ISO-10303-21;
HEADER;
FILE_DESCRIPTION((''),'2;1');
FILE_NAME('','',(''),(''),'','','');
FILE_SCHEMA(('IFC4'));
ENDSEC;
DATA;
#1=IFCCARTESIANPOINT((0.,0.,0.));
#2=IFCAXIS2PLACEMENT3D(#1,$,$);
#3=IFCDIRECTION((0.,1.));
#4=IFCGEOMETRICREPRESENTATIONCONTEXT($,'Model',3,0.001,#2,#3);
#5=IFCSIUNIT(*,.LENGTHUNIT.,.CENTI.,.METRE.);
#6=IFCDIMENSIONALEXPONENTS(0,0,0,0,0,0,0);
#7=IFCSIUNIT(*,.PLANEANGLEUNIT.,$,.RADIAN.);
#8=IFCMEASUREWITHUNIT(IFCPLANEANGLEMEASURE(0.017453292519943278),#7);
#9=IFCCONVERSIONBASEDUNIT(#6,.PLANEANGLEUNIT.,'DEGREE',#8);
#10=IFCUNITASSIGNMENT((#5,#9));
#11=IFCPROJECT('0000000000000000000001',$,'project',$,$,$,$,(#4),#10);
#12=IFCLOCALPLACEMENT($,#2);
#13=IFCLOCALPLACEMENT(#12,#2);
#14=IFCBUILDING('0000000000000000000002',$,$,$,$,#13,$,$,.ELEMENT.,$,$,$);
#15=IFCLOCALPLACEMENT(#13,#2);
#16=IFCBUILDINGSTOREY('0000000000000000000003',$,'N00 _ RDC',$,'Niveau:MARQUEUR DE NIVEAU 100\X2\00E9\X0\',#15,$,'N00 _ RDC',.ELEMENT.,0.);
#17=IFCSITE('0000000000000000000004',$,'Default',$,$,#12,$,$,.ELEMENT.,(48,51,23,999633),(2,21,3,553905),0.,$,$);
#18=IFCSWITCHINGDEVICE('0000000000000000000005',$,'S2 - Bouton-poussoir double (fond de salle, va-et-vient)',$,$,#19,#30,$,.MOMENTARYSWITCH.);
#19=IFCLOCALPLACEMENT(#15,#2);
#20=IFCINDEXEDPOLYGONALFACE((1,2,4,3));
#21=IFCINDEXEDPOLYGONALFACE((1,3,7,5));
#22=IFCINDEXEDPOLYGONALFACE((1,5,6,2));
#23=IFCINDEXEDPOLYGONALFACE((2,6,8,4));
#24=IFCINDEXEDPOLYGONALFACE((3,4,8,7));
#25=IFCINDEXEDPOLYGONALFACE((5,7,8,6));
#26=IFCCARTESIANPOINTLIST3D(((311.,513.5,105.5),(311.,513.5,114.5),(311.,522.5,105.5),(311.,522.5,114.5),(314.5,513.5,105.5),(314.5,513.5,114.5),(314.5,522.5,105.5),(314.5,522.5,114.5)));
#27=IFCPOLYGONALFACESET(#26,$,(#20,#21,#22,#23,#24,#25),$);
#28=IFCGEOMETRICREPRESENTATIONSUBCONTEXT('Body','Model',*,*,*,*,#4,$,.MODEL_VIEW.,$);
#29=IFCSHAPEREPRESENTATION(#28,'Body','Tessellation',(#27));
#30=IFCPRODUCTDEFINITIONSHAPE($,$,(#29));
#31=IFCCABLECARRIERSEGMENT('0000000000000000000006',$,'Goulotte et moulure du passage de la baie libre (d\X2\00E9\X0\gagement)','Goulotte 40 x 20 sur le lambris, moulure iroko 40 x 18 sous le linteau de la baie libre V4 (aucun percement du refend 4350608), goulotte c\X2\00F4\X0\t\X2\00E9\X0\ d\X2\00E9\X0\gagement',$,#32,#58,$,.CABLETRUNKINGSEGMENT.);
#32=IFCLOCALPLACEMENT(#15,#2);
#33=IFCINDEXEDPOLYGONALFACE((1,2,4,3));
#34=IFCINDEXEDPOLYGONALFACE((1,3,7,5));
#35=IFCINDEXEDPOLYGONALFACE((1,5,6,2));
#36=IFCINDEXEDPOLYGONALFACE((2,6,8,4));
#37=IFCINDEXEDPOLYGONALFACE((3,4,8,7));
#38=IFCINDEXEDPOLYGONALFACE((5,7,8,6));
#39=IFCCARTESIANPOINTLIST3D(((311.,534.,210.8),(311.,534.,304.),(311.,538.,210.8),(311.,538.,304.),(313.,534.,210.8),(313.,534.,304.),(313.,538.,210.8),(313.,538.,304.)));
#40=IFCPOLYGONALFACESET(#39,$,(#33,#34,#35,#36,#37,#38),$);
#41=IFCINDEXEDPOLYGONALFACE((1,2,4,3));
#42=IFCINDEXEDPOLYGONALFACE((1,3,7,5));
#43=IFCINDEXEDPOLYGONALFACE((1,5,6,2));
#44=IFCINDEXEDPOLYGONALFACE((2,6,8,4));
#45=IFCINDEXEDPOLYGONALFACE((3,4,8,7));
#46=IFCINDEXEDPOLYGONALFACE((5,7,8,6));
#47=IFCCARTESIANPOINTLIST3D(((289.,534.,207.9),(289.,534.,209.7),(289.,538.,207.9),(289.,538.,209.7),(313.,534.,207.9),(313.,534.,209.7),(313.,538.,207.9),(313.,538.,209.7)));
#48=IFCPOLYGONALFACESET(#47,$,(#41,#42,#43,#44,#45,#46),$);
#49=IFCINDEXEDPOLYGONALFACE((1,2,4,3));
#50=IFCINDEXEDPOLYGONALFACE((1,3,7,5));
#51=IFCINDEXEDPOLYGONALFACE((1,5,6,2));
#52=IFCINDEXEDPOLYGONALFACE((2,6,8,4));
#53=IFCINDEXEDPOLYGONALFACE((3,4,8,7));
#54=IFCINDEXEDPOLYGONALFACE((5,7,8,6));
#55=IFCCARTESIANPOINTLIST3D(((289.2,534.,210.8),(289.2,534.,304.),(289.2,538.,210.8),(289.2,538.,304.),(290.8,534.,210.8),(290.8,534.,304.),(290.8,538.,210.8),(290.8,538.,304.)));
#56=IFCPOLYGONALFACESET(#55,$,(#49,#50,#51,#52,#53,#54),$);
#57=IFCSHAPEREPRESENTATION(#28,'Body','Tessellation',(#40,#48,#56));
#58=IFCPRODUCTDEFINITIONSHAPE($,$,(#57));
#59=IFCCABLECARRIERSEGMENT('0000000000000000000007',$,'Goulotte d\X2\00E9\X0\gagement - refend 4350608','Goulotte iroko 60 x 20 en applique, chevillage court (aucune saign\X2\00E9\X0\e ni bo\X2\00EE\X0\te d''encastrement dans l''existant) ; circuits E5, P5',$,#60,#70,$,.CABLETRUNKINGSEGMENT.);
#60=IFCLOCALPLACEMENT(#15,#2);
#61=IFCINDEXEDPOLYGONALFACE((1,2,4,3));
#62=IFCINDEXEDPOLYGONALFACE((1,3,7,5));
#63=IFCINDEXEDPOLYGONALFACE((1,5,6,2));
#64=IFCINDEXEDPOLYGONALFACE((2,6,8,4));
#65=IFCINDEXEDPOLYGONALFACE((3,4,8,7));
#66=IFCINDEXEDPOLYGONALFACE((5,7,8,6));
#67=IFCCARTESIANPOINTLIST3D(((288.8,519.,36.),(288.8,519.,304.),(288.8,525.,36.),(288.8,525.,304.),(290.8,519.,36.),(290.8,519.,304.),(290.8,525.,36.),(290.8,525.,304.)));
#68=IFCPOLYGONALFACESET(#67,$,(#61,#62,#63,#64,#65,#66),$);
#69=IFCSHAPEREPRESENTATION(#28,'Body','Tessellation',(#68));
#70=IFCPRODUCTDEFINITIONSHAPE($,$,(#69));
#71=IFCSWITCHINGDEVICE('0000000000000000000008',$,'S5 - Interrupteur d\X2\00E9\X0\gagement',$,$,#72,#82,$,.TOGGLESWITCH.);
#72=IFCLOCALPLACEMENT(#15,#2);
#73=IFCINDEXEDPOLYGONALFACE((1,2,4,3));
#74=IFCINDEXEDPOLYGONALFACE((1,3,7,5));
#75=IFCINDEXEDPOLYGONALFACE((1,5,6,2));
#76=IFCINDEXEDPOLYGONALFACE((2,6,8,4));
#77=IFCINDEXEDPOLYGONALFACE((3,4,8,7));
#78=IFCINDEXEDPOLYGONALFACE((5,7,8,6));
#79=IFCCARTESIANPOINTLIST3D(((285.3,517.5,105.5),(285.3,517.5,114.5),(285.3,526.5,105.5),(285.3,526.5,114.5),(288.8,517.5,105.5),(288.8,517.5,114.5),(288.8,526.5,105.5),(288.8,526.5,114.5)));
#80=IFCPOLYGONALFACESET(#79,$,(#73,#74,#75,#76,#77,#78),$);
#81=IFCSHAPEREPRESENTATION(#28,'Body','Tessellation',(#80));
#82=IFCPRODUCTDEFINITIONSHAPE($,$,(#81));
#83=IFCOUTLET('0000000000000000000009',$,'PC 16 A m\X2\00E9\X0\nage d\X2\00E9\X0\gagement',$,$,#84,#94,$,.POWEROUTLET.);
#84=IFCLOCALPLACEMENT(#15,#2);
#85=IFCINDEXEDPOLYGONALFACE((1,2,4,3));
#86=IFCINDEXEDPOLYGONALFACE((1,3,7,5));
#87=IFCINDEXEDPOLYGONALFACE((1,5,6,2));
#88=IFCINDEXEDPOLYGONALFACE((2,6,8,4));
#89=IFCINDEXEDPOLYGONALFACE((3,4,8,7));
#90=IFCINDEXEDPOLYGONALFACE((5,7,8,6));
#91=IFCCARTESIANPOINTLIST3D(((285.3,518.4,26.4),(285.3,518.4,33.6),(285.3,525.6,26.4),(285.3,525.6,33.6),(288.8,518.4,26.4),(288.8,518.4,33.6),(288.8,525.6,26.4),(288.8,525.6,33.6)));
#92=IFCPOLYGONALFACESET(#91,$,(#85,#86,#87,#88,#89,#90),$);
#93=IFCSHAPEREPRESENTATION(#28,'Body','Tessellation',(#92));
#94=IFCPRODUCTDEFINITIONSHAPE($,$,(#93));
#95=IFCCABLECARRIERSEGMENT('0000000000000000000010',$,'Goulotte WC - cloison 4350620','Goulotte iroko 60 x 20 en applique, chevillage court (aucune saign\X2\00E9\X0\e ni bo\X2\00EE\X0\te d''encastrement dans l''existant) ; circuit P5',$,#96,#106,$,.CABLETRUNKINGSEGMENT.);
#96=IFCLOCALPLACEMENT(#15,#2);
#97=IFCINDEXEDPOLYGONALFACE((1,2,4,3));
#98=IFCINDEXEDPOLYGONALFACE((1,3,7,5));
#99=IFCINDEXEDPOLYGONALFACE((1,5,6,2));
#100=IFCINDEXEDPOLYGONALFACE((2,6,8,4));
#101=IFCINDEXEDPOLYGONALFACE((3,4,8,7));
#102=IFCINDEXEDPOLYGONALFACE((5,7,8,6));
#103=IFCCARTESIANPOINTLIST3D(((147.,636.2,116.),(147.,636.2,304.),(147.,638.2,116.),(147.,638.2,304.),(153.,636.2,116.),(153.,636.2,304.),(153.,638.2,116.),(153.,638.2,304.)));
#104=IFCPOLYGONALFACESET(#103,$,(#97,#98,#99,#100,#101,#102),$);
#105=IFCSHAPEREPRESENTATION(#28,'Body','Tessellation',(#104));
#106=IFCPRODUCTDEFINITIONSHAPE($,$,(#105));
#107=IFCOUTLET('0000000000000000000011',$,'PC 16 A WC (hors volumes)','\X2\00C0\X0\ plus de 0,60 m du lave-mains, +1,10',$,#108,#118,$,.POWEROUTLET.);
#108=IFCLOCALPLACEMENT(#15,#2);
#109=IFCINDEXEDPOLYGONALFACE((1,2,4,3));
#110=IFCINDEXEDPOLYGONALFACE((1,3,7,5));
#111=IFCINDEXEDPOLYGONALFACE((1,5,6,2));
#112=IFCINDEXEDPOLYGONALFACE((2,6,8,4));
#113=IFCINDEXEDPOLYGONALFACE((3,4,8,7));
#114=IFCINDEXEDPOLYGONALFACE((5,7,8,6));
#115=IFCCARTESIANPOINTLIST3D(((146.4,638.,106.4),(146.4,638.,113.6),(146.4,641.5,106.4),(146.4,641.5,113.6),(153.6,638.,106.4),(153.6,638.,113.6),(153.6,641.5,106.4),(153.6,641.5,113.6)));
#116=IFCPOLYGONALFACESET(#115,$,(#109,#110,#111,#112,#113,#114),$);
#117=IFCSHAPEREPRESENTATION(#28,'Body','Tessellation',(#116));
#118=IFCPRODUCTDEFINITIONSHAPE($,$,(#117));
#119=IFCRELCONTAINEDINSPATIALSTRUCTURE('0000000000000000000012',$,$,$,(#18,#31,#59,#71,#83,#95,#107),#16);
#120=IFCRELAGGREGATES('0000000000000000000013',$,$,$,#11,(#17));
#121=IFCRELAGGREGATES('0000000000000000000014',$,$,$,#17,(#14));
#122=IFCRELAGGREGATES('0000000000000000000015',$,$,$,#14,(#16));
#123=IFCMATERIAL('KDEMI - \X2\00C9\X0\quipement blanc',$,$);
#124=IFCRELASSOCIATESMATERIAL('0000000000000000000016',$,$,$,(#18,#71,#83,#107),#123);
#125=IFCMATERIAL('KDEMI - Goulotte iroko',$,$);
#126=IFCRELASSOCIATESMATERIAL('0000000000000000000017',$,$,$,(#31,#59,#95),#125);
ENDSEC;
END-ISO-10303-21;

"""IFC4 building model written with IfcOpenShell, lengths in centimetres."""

from ifc_helpers import new_model, entity, si_unit, converted_unit, direction, frame, frame_2d, origin, origin_with_axes, place, context, subcontext, project, spatial, rectangle, extrude, material, element, save


model = new_model("IFC4")

# Units and contexts
model_context = context("Model", 3, precision=0.001, world=origin(), true_north=direction((0.0, 1.0)))
body_context = subcontext(model_context, "Body", "Model", "MODEL_VIEW")
ifc_project = project(units=[si_unit("LENGTHUNIT", "METRE", prefix="CENTI"), converted_unit("PLANEANGLEUNIT", "DEGREE", entity("IfcPlaneAngleMeasure", 0.017453292519943278), si_unit("PLANEANGLEUNIT", "RADIAN"), dimensions=[0, 0, 0, 0, 0, 0, 0])], contexts=[model_context])

# Site, building, storey
site_placement = place(None, origin())
site = spatial("IfcSite", under=ifc_project, at=site_placement, Name="Default", CompositionType="ELEMENT", RefLatitude=(48, 51, 23, 999633), RefLongitude=(2, 21, 3, 553905), RefElevation=0.0)
building_placement = place(site_placement, origin())
building = spatial("IfcBuilding", under=site, at=building_placement, CompositionType="ELEMENT")
storey_placement = place(building_placement, origin())
storey = spatial("IfcBuildingStorey", under=building, at=storey_placement, Name="N00 _ RDC", ObjectType="Niveau:MARQUEUR DE NIVEAU 100é", LongName="N00 _ RDC", CompositionType="ELEMENT", Elevation=0.0)

# Shared definitions
ifc_material_1 = material(Name="KDEMI - Goulotte iroko")

# Shared definitions
ifc_material_2 = material(Name="KDEMI - Équipement blanc")

# Switching device
switching_device_1_placement = place(storey_placement, origin_with_axes())
element("IfcSwitchingDevice", 1, at=switching_device_1_placement, inside=storey, material=ifc_material_2, Name="S2 - Bouton-poussoir double (fond de salle, va-et-vient)", PredefinedType="MOMENTARYSWITCH", context=body_context, shape_type="SweptSolid", body=[
    extrude(rectangle(XDim=3.5, YDim=9.0, at=frame_2d((312.75, 518.0))), frame((0.0, 0.0, 105.5)), (0.0, 0.0, 1.0), 9.0),
])

# Cable carrier segments
cable_carrier_segment_1_placement = place(storey_placement, origin_with_axes())
element("IfcCableCarrierSegment", 2, at=cable_carrier_segment_1_placement, inside=storey, material=ifc_material_1, Name="Goulotte et moulure du passage de la baie libre (dégagement)", Description="Goulotte 40 x 20 sur le lambris, moulure iroko 40 x 18 sous le linteau de la baie libre V4 (aucun percement du refend 4350608), goulotte côté dégagement", PredefinedType="CABLETRUNKINGSEGMENT", context=body_context, shape_type="SweptSolid", body=[
    extrude(rectangle(XDim=2.0, YDim=4.0, at=frame_2d((312.0, 536.0))), frame((0.0, 0.0, 210.8)), (0.0, 0.0, 1.0), 93.2),
    extrude(rectangle(XDim=24.0, YDim=4.0, at=frame_2d((301.0, 536.0))), frame((0.0, 0.0, 207.9)), (0.0, 0.0, 1.0), 1.8),
    extrude(rectangle(XDim=1.6, YDim=4.0, at=frame_2d((290.0, 536.0))), frame((0.0, 0.0, 210.8)), (0.0, 0.0, 1.0), 93.2),
])
cable_carrier_segment_2_placement = place(storey_placement, origin_with_axes())
element("IfcCableCarrierSegment", 3, at=cable_carrier_segment_2_placement, inside=storey, material=ifc_material_1, Name="Goulotte dégagement - refend 4350608", Description="Goulotte iroko 60 x 20 en applique, chevillage court (aucune saignée ni boîte d'encastrement dans l'existant) ; circuits E5, P5", PredefinedType="CABLETRUNKINGSEGMENT", context=body_context, shape_type="SweptSolid", body=[
    extrude(rectangle(XDim=2.0, YDim=6.0, at=frame_2d((289.8, 522.0))), frame((0.0, 0.0, 36.0)), (0.0, 0.0, 1.0), 268.0),
])

# Switching device
switching_device_2_placement = place(storey_placement, origin_with_axes())
element("IfcSwitchingDevice", 4, at=switching_device_2_placement, inside=storey, material=ifc_material_2, Name="S5 - Interrupteur dégagement", PredefinedType="TOGGLESWITCH", context=body_context, shape_type="SweptSolid", body=[
    extrude(rectangle(XDim=3.5, YDim=9.0, at=frame_2d((287.05, 522.0))), frame((0.0, 0.0, 105.5)), (0.0, 0.0, 1.0), 9.0),
])

# Outlet
outlet_1_placement = place(storey_placement, origin_with_axes())
element("IfcOutlet", 5, at=outlet_1_placement, inside=storey, material=ifc_material_2, Name="PC 16 A ménage dégagement", PredefinedType="POWEROUTLET", context=body_context, shape_type="SweptSolid", body=[
    extrude(rectangle(XDim=3.5, YDim=7.2, at=frame_2d((287.05, 522.0))), frame((0.0, 0.0, 26.4)), (0.0, 0.0, 1.0), 7.2),
])

# Cable carrier segment
cable_carrier_segment_3_placement = place(storey_placement, origin_with_axes())
element("IfcCableCarrierSegment", 6, at=cable_carrier_segment_3_placement, inside=storey, material=ifc_material_1, Name="Goulotte WC - cloison 4350620", Description="Goulotte iroko 60 x 20 en applique, chevillage court (aucune saignée ni boîte d'encastrement dans l'existant) ; circuit P5", PredefinedType="CABLETRUNKINGSEGMENT", context=body_context, shape_type="SweptSolid", body=[
    extrude(rectangle(XDim=6.0, YDim=2.0, at=frame_2d((150.0, 637.2))), frame((0.0, 0.0, 116.0)), (0.0, 0.0, 1.0), 188.0),
])

# Outlet
outlet_2_placement = place(storey_placement, origin_with_axes())
element("IfcOutlet", 7, at=outlet_2_placement, inside=storey, material=ifc_material_2, Name="PC 16 A WC (hors volumes)", Description="À plus de 0,60 m du lave-mains, +1,10", PredefinedType="POWEROUTLET", context=body_context, shape_type="SweptSolid", body=[
    extrude(rectangle(XDim=7.2, YDim=3.5, at=frame_2d((150.0, 639.75))), frame((0.0, 0.0, 106.4)), (0.0, 0.0, 1.0), 7.2),
])

save(model, "model.ifc")
